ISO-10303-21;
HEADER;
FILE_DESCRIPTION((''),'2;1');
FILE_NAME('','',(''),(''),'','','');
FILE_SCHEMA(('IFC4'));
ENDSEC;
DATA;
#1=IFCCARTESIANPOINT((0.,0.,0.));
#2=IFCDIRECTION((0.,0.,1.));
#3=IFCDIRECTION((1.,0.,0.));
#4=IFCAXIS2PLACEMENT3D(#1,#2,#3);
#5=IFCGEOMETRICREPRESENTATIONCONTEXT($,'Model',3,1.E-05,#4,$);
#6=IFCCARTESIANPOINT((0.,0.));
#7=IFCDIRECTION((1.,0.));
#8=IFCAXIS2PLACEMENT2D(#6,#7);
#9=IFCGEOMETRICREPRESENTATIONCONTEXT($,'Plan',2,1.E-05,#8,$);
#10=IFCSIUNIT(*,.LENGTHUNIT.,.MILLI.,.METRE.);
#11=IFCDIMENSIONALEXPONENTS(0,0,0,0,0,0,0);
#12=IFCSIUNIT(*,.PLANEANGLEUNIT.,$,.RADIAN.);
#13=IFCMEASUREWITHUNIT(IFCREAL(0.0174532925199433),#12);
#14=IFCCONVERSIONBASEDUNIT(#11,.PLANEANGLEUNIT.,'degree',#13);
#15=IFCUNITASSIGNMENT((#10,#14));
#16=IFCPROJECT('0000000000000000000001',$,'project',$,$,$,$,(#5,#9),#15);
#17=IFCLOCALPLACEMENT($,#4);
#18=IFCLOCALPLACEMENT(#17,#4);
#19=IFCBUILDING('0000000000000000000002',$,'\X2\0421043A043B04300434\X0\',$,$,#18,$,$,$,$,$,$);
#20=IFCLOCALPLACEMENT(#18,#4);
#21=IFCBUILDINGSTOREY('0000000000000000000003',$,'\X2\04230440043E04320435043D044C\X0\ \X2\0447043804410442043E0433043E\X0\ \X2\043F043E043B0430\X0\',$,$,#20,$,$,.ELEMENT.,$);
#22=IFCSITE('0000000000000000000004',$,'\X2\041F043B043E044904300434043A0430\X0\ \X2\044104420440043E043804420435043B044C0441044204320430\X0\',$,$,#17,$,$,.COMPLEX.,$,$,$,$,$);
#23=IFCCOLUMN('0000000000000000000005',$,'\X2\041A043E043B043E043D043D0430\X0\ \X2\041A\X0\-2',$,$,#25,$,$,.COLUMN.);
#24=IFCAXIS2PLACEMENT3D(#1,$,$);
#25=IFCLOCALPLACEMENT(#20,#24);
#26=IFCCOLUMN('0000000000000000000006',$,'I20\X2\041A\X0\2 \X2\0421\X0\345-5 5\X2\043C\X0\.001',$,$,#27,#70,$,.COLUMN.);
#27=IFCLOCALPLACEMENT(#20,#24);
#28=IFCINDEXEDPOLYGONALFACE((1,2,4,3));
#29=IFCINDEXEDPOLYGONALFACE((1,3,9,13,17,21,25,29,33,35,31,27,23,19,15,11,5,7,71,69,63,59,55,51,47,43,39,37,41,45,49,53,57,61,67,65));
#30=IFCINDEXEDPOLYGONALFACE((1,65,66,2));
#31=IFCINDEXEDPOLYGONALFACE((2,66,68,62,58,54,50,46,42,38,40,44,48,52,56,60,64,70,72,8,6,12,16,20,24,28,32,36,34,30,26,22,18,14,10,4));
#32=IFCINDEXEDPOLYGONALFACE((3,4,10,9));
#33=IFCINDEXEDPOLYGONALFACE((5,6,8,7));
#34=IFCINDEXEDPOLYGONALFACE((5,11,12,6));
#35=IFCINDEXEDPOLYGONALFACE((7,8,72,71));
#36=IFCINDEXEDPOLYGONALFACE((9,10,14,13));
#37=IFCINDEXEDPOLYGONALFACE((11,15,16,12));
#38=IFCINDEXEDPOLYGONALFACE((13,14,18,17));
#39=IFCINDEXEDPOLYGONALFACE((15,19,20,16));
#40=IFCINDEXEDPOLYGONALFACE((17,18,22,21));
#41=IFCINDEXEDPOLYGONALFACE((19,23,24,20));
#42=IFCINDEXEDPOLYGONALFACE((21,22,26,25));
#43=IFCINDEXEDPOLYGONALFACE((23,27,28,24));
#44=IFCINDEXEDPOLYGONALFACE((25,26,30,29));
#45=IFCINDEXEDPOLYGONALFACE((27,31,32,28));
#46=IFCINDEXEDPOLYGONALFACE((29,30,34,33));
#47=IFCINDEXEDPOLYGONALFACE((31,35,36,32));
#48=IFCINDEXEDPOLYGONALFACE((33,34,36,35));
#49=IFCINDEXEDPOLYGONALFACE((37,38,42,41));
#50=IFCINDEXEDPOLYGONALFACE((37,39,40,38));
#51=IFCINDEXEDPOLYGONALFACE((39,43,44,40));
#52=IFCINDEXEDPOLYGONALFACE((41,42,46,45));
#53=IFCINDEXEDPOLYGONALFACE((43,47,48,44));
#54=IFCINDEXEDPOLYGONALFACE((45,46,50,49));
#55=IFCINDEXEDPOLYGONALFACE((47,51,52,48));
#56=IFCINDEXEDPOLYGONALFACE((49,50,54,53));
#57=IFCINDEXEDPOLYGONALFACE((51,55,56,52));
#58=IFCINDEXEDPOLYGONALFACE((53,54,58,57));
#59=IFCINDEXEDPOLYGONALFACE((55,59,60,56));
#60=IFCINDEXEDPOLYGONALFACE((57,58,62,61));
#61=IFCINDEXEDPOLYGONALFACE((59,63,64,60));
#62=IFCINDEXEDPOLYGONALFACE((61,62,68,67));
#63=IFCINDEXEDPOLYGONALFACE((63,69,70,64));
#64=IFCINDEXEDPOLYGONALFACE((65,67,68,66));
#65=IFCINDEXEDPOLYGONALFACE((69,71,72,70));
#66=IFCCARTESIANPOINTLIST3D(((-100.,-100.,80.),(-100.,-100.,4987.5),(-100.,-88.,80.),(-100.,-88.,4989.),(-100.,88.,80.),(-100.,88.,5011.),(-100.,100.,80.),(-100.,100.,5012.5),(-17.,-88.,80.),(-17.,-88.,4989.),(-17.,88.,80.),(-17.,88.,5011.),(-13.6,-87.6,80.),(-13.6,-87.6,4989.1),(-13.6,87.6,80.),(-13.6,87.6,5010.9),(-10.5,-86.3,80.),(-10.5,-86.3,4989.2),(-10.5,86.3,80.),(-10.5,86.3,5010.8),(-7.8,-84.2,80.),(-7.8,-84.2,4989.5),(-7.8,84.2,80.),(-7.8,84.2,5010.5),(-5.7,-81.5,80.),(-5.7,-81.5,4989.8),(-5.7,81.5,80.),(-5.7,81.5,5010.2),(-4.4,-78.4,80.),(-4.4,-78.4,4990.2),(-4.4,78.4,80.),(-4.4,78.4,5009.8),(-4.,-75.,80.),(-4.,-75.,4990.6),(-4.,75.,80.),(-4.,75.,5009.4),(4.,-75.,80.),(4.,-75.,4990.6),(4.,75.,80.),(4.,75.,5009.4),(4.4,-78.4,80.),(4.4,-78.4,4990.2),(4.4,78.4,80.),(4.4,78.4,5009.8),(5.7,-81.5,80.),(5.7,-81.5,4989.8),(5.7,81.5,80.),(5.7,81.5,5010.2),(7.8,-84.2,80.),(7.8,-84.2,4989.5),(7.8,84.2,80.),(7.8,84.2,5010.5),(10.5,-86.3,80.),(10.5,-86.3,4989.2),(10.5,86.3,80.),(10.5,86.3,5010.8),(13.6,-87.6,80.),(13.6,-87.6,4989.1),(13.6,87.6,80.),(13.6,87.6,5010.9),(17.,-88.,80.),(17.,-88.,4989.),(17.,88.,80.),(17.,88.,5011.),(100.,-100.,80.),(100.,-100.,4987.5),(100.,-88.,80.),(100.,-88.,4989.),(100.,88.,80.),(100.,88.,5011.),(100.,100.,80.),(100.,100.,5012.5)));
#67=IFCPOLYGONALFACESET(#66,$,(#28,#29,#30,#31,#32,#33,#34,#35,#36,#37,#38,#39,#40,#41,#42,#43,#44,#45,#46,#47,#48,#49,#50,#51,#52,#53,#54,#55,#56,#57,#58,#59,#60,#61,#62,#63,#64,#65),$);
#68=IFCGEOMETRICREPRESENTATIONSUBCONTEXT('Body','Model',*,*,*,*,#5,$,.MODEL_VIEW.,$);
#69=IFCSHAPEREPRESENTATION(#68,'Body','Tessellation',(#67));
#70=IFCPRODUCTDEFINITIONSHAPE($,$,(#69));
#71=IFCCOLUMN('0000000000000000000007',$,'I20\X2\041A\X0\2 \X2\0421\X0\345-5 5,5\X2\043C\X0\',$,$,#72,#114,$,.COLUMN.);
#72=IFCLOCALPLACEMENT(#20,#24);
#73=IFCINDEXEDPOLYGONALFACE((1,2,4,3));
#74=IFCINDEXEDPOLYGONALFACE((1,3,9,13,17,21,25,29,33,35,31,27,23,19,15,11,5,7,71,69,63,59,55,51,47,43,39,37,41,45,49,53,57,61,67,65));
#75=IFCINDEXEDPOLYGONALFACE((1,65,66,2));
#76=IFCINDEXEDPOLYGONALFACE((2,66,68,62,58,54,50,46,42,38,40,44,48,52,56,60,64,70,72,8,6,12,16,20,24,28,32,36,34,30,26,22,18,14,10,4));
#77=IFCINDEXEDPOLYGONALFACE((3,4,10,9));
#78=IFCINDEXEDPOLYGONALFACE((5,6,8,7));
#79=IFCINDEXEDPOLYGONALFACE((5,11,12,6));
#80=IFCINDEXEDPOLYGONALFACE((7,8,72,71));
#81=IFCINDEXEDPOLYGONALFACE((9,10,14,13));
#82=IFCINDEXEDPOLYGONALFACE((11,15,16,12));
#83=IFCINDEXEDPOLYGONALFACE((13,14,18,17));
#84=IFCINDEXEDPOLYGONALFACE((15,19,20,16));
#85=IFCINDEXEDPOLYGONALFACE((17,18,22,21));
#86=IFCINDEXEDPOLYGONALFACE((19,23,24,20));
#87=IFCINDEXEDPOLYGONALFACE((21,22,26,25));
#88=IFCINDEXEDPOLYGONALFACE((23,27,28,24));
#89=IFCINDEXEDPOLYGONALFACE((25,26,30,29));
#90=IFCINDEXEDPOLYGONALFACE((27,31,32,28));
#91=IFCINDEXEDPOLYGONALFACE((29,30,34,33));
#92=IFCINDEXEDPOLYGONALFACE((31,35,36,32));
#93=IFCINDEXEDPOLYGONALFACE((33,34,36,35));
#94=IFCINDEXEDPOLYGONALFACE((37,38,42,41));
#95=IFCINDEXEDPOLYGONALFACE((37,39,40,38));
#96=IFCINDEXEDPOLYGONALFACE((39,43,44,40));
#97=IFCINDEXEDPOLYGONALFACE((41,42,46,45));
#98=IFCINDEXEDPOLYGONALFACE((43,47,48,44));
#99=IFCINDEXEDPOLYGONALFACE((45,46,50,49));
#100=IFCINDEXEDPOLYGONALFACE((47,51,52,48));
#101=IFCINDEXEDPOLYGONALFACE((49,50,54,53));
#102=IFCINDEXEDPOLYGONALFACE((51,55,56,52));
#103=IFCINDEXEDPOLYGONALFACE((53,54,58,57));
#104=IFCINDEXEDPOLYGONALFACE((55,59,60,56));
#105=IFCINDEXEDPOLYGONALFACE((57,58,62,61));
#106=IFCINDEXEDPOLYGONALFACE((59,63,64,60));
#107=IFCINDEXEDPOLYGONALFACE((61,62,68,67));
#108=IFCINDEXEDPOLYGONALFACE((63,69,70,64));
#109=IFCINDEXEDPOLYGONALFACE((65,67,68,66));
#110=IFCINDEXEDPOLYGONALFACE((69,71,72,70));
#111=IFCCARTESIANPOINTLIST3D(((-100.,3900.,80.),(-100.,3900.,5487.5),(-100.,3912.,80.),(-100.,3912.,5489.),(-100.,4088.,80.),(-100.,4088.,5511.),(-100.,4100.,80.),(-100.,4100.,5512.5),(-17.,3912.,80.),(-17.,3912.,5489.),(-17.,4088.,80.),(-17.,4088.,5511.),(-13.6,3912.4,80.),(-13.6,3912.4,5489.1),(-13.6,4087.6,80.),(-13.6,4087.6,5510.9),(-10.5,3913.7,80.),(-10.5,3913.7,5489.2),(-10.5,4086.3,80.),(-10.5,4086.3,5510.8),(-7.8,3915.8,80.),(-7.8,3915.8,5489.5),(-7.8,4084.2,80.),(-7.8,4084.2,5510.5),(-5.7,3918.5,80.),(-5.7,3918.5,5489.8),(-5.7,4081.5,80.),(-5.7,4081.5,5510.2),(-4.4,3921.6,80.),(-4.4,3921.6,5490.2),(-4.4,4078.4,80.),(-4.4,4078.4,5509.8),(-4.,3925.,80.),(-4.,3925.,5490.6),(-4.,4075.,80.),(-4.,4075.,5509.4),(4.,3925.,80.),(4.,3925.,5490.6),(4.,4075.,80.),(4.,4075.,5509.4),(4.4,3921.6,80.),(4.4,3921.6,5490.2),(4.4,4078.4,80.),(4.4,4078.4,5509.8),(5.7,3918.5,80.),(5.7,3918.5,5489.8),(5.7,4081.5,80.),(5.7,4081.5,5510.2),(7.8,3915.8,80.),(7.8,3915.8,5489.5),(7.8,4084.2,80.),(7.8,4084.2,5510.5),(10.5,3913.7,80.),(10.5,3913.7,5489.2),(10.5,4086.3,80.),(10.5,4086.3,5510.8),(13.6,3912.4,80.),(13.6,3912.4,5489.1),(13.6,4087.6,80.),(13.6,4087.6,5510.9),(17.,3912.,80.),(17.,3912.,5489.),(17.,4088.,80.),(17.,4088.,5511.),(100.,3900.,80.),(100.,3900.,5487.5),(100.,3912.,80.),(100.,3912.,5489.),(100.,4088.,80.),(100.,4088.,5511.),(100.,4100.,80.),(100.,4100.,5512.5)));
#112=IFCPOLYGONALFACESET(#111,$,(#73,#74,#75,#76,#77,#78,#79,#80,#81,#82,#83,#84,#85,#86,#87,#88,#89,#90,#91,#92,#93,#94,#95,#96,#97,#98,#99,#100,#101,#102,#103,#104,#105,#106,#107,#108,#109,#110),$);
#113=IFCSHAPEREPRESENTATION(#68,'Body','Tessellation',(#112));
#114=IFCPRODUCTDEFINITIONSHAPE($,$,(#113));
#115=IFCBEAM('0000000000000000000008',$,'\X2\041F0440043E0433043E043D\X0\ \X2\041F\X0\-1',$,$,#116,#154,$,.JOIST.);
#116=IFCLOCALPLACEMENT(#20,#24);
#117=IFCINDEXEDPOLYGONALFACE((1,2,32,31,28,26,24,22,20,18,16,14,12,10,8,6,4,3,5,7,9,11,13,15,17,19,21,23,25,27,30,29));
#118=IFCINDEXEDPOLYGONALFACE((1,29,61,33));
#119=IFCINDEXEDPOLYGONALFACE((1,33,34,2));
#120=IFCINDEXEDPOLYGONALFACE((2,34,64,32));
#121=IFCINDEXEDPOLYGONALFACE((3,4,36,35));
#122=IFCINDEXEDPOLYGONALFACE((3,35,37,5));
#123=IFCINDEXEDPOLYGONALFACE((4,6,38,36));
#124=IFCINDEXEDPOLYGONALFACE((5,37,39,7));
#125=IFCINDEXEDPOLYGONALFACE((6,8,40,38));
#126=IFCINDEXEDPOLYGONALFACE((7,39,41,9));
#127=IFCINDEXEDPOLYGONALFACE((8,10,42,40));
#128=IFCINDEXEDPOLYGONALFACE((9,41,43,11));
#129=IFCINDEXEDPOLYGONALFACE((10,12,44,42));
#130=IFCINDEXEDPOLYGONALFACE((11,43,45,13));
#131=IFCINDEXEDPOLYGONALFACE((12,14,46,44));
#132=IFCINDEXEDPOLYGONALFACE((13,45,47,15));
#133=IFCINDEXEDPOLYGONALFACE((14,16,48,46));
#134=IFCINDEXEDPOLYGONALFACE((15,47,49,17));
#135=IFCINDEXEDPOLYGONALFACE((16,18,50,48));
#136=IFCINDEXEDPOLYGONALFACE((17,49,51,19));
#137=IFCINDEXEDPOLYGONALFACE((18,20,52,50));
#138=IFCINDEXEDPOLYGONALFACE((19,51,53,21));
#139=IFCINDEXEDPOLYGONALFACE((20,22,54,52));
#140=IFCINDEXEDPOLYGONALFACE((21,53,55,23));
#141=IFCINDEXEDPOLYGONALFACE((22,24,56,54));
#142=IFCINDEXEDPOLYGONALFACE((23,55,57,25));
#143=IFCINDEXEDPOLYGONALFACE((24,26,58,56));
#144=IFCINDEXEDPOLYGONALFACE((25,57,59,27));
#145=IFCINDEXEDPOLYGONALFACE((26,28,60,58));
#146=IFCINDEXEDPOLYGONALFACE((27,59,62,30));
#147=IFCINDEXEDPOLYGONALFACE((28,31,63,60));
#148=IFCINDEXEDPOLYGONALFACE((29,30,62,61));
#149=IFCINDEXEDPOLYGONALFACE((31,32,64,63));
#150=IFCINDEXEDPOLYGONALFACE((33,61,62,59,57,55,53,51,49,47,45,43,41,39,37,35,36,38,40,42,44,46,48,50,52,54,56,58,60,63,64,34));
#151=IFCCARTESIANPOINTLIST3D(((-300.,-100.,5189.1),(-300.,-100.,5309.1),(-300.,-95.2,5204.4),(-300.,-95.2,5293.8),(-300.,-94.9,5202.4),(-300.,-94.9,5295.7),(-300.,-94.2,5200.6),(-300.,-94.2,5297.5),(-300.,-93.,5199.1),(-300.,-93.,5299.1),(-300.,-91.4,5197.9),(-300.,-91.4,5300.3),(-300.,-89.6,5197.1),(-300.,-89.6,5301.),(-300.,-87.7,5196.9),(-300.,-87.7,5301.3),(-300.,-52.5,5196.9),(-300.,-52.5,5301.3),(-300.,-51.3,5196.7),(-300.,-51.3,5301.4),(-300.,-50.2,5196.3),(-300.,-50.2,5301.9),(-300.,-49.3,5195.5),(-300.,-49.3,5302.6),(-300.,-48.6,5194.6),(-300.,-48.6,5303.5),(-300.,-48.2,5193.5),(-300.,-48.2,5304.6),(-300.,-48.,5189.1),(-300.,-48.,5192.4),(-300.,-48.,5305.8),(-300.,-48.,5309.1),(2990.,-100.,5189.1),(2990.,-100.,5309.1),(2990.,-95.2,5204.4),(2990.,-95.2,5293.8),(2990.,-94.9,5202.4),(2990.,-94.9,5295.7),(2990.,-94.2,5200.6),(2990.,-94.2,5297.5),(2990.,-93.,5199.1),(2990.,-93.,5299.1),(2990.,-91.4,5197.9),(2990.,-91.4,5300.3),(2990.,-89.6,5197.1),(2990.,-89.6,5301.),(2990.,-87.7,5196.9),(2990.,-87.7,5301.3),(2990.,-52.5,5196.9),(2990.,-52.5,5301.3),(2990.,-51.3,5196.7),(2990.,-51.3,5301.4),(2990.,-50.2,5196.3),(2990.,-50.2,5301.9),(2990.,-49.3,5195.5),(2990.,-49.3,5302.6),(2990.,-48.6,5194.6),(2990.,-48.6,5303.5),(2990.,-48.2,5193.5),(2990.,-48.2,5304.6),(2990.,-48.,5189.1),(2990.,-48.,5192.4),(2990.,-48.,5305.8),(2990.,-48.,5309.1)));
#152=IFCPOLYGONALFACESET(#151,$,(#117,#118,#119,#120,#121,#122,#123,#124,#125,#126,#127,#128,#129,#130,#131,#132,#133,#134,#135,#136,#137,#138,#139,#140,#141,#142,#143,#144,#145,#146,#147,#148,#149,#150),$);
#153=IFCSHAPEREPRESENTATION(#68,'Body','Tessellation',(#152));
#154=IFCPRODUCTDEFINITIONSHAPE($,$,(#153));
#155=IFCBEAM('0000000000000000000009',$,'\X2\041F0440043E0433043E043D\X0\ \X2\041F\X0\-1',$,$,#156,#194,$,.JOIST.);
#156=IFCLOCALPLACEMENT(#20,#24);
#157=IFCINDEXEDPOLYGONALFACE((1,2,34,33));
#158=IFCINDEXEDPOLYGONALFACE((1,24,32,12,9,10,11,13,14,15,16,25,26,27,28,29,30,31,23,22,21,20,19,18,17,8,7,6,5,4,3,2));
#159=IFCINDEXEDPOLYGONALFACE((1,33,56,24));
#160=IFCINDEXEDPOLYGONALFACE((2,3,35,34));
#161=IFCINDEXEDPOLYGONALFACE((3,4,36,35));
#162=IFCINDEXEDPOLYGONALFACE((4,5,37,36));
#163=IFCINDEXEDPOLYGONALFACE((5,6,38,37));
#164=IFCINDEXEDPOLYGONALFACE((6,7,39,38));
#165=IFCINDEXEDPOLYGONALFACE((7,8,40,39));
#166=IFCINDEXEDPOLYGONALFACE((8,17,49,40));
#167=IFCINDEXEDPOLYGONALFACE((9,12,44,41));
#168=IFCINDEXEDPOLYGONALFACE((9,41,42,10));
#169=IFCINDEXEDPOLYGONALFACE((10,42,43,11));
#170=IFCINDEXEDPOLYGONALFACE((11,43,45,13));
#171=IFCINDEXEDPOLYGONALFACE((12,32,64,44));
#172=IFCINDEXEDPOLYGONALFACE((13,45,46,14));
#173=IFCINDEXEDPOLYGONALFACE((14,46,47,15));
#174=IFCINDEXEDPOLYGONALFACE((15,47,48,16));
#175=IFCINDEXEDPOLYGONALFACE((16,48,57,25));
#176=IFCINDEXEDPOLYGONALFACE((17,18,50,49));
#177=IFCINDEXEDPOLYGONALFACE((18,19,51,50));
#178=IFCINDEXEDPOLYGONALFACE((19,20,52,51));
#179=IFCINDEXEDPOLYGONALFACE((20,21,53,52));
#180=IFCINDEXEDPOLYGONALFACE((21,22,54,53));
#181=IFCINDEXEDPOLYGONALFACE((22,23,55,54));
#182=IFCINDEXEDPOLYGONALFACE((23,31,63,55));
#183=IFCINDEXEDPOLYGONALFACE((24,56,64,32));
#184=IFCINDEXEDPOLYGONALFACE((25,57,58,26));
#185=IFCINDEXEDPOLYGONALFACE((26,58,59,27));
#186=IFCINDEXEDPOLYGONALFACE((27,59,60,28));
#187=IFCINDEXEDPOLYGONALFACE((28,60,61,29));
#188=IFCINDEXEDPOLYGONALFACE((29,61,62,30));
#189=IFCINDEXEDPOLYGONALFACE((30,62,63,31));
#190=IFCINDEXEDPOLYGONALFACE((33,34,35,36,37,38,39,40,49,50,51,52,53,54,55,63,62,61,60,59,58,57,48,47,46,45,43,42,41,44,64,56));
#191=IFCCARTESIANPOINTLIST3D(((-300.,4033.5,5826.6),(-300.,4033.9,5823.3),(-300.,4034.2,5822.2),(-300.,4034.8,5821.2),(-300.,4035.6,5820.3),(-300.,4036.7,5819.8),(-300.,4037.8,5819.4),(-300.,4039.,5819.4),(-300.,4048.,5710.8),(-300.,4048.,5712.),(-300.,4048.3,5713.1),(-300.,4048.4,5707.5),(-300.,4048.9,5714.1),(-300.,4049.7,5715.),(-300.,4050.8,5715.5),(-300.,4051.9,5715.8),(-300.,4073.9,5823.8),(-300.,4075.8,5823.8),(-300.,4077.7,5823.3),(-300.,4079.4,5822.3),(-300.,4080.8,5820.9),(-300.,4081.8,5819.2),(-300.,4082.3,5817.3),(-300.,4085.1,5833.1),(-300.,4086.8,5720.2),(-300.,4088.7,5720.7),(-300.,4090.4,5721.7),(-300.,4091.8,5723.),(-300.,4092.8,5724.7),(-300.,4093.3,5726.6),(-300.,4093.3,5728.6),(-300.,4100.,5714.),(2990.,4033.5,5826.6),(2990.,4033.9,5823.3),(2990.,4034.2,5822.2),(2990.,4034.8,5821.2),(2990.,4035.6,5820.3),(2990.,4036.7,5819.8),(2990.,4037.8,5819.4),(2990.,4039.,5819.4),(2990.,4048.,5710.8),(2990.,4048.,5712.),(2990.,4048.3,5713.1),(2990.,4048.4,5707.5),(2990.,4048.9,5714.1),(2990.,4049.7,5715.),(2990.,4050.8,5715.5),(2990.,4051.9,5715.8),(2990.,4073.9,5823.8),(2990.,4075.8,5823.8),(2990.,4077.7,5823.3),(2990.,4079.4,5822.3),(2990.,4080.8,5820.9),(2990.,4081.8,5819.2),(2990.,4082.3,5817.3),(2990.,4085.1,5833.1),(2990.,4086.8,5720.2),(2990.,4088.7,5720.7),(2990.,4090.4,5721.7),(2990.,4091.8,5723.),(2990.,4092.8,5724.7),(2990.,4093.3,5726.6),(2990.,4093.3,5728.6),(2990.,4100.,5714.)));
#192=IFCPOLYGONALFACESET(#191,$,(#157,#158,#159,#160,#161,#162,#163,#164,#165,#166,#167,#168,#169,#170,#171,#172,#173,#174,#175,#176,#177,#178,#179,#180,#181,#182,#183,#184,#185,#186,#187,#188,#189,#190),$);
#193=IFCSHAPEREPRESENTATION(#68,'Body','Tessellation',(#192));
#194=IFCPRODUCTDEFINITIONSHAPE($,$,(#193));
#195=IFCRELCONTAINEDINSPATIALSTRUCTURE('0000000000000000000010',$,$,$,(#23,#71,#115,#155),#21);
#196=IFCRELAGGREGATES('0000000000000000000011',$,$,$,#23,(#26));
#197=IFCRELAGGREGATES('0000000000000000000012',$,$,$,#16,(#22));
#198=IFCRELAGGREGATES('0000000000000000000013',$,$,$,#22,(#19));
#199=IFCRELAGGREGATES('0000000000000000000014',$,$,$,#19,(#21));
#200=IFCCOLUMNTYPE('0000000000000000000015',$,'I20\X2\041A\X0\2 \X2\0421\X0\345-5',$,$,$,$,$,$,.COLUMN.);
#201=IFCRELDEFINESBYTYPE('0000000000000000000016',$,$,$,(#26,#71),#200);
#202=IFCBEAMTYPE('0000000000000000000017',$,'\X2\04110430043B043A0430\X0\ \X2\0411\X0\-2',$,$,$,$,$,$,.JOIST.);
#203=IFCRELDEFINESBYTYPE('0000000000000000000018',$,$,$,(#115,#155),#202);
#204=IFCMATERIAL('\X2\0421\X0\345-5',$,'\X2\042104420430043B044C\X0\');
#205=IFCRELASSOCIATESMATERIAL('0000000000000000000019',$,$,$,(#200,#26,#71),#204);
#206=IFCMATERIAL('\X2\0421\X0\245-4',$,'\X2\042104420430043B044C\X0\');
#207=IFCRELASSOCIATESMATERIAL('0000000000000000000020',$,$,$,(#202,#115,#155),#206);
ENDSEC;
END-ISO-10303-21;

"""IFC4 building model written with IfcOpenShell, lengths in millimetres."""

from ifc_helpers import new_model, entity, si_unit, converted_unit, frame, origin_with_axes, origin_2d_with_axis, place, context, subcontext, project, spatial, i_section, u_section, extrude, boolean, clip, halfspace, material, material_profile, profile_set, profile_usage, type_object, element, aggregate, save


model = new_model("IFC4")

# Units and contexts
model_context = context("Model", 3, precision=1e-05, world=origin_with_axes())
plan_context = context("Plan", 2, precision=1e-05, world=origin_2d_with_axis())
body_context = subcontext(model_context, "Body", "Model", "MODEL_VIEW")
ifc_project = project(units=[si_unit("LENGTHUNIT", "METRE", prefix="MILLI"), converted_unit("PLANEANGLEUNIT", "degree", entity("IfcReal", 0.0174532925199433), si_unit("PLANEANGLEUNIT", "RADIAN"), dimensions=[0, 0, 0, 0, 0, 0, 0])], contexts=[model_context, plan_context])

# Site, building, storey
site_placement = place(None, origin_with_axes())
site = spatial("IfcSite", under=ifc_project, at=site_placement, Name="Площадка строительства", CompositionType="COMPLEX")
building_placement = place(site_placement, origin_with_axes())
building = spatial("IfcBuilding", under=site, at=building_placement, Name="Склад")
storey_placement = place(building_placement, origin_with_axes())
storey = spatial("IfcBuildingStorey", under=building, at=storey_placement, Name="Уровень чистого пола", CompositionType="ELEMENT")

# Columns
placement_1 = place(storey_placement, origin_with_axes())
column_1 = element("IfcColumn", 1, at=placement_1, inside=storey, Name="Колонна К-2", PredefinedType="COLUMN")
ifc_material_1 = material(Name="С345-5", Category="Сталь")
ifc_material_profile_1 = material_profile(ifc_material_1, i_section(OverallWidth=200.0, OverallDepth=200.0, WebThickness=8.0, FlangeThickness=12.0, FilletRadius=13.0, FlangeEdgeRadius=0.0, FlangeSlope=0.0))
ifc_profile_set_1 = profile_set([ifc_material_profile_1], Name="I20К2_С345-5")
ifc_profile_usage_1 = profile_usage(ifc_profile_set_1, cardinal=5)
column_type = type_object("IfcColumnType", Name="I20К2 С345-5", PredefinedType="COLUMN", material=ifc_profile_set_1)
placement_2 = place(placement_1, origin_with_axes())
column_2 = element("IfcColumn", 2, at=placement_2, type_object=column_type, material=ifc_profile_usage_1, Name="I20К2 С345-5 5м.001", PredefinedType="COLUMN", context=body_context, shape_type="Clipping", body=[
    boolean("DIFFERENCE", clip(extrude(i_section(OverallWidth=200.0, OverallDepth=200.0, WebThickness=8.0, FlangeThickness=12.0, FilletRadius=13.0, FlangeEdgeRadius=0.0, FlangeSlope=0.0), origin_with_axes(), (0.0, 0.0, 1.0), 5200.0), halfspace(frame((0.0, -298.5, 4962.7), z_axis=(0.0, -0.124035, 0.992278), x_axis=(0.0, 0.992278, 0.124035)), False)), halfspace(frame((0.0, 0.0, 80.0), z_axis=(0.0, 0.0, -1.0), x_axis=(1.0, 0.0, 0.0)), False)),
])

# Column
column_3_placement = place(storey_placement, frame((0.0, 4000.0, 0.0), z_axis=(0.0, 0.0, 1.0), x_axis=(1.0, 0.0, 0.0)))
element("IfcColumn", 3, at=column_3_placement, inside=storey, type_object=column_type, material=ifc_profile_usage_1, Name="I20К2 С345-5 5,5м", PredefinedType="COLUMN", context=body_context, shape_type="Clipping", body=[
    boolean("DIFFERENCE", clip(extrude(i_section(OverallWidth=200.0, OverallDepth=200.0, WebThickness=8.0, FlangeThickness=12.0, FilletRadius=13.0, FlangeEdgeRadius=0.0, FlangeSlope=0.0), origin_with_axes(), (0.0, 0.0, 1.0), 5700.0), halfspace(frame((0.0, -4298.5, 4962.7), z_axis=(0.0, -0.124035, 0.992278), x_axis=(0.0, 0.992278, 0.124035)), False)), halfspace(frame((0.0, 0.0, 80.0), z_axis=(0.0, 0.0, -1.0), x_axis=(1.0, 0.0, 0.0)), False)),
])

# Beams
ifc_material_2 = material(Name="С245-4", Category="Сталь")
ifc_material_profile_2 = material_profile(ifc_material_2, u_section(Depth=120.0, FlangeWidth=52.0, WebThickness=4.8, FlangeThickness=7.8, FilletRadius=7.5, EdgeRadius=4.5, FlangeSlope=0.0))
ifc_profile_set_2 = profile_set([ifc_material_profile_2], Name="U12P_S245-4")
ifc_profile_usage_2 = profile_usage(ifc_profile_set_2, cardinal=3)
beam_type_1 = type_object("IfcBeamType", Name="Балка Б-2", PredefinedType="JOIST", material=ifc_profile_set_2)
beam_1_placement = place(storey_placement, frame((-300.0, -100.0, 5189.1), z_axis=(1.0, 0.0, 0.0), x_axis=(0.0, 1.0, 0.0)))
element("IfcBeam", 4, at=beam_1_placement, inside=storey, type_object=beam_type_1, material=ifc_profile_usage_2, Name="Прогон П-1", PredefinedType="JOIST", context=body_context, shape_type="SweptSolid", body=[
    extrude(u_section(Depth=120.0, FlangeWidth=52.0, WebThickness=4.8, FlangeThickness=7.8, FilletRadius=7.5, EdgeRadius=4.5, FlangeSlope=0.0), frame((26.0, 60.0, 0.0), z_axis=(0.0, 0.0, 1.0), x_axis=(1.0, 0.0, 0.0)), (0.0, 0.0, 1.0), 3290.0),
])
for number, where, z_axis, x_axis, name in (
    (5, (2990.0, 4100.0, 5714.0), (-1.0, 0.0, 0.0), (0.0, -0.99228, -0.124019), "Прогон П-1"),
):
    element("IfcBeam", number, at=place(storey_placement, frame(where, z_axis=z_axis, x_axis=x_axis)), inside=storey, type_object=beam_type_1, material=ifc_profile_usage_2, Name=name, PredefinedType="JOIST", context=body_context, shape_type="SweptSolid", body=[
        extrude(u_section(Depth=120.0, FlangeWidth=52.0, WebThickness=4.8, FlangeThickness=7.8, FilletRadius=7.5, EdgeRadius=4.5, FlangeSlope=0.0), frame((26.0, 60.0, 0.0), z_axis=(0.0, 0.0, 1.0), x_axis=(1.0, 0.0, 0.0)), (0.0, 0.0, 1.0), 3290.0),
    ])

aggregate(column_1, [column_2])

save(model, "model.ifc")
